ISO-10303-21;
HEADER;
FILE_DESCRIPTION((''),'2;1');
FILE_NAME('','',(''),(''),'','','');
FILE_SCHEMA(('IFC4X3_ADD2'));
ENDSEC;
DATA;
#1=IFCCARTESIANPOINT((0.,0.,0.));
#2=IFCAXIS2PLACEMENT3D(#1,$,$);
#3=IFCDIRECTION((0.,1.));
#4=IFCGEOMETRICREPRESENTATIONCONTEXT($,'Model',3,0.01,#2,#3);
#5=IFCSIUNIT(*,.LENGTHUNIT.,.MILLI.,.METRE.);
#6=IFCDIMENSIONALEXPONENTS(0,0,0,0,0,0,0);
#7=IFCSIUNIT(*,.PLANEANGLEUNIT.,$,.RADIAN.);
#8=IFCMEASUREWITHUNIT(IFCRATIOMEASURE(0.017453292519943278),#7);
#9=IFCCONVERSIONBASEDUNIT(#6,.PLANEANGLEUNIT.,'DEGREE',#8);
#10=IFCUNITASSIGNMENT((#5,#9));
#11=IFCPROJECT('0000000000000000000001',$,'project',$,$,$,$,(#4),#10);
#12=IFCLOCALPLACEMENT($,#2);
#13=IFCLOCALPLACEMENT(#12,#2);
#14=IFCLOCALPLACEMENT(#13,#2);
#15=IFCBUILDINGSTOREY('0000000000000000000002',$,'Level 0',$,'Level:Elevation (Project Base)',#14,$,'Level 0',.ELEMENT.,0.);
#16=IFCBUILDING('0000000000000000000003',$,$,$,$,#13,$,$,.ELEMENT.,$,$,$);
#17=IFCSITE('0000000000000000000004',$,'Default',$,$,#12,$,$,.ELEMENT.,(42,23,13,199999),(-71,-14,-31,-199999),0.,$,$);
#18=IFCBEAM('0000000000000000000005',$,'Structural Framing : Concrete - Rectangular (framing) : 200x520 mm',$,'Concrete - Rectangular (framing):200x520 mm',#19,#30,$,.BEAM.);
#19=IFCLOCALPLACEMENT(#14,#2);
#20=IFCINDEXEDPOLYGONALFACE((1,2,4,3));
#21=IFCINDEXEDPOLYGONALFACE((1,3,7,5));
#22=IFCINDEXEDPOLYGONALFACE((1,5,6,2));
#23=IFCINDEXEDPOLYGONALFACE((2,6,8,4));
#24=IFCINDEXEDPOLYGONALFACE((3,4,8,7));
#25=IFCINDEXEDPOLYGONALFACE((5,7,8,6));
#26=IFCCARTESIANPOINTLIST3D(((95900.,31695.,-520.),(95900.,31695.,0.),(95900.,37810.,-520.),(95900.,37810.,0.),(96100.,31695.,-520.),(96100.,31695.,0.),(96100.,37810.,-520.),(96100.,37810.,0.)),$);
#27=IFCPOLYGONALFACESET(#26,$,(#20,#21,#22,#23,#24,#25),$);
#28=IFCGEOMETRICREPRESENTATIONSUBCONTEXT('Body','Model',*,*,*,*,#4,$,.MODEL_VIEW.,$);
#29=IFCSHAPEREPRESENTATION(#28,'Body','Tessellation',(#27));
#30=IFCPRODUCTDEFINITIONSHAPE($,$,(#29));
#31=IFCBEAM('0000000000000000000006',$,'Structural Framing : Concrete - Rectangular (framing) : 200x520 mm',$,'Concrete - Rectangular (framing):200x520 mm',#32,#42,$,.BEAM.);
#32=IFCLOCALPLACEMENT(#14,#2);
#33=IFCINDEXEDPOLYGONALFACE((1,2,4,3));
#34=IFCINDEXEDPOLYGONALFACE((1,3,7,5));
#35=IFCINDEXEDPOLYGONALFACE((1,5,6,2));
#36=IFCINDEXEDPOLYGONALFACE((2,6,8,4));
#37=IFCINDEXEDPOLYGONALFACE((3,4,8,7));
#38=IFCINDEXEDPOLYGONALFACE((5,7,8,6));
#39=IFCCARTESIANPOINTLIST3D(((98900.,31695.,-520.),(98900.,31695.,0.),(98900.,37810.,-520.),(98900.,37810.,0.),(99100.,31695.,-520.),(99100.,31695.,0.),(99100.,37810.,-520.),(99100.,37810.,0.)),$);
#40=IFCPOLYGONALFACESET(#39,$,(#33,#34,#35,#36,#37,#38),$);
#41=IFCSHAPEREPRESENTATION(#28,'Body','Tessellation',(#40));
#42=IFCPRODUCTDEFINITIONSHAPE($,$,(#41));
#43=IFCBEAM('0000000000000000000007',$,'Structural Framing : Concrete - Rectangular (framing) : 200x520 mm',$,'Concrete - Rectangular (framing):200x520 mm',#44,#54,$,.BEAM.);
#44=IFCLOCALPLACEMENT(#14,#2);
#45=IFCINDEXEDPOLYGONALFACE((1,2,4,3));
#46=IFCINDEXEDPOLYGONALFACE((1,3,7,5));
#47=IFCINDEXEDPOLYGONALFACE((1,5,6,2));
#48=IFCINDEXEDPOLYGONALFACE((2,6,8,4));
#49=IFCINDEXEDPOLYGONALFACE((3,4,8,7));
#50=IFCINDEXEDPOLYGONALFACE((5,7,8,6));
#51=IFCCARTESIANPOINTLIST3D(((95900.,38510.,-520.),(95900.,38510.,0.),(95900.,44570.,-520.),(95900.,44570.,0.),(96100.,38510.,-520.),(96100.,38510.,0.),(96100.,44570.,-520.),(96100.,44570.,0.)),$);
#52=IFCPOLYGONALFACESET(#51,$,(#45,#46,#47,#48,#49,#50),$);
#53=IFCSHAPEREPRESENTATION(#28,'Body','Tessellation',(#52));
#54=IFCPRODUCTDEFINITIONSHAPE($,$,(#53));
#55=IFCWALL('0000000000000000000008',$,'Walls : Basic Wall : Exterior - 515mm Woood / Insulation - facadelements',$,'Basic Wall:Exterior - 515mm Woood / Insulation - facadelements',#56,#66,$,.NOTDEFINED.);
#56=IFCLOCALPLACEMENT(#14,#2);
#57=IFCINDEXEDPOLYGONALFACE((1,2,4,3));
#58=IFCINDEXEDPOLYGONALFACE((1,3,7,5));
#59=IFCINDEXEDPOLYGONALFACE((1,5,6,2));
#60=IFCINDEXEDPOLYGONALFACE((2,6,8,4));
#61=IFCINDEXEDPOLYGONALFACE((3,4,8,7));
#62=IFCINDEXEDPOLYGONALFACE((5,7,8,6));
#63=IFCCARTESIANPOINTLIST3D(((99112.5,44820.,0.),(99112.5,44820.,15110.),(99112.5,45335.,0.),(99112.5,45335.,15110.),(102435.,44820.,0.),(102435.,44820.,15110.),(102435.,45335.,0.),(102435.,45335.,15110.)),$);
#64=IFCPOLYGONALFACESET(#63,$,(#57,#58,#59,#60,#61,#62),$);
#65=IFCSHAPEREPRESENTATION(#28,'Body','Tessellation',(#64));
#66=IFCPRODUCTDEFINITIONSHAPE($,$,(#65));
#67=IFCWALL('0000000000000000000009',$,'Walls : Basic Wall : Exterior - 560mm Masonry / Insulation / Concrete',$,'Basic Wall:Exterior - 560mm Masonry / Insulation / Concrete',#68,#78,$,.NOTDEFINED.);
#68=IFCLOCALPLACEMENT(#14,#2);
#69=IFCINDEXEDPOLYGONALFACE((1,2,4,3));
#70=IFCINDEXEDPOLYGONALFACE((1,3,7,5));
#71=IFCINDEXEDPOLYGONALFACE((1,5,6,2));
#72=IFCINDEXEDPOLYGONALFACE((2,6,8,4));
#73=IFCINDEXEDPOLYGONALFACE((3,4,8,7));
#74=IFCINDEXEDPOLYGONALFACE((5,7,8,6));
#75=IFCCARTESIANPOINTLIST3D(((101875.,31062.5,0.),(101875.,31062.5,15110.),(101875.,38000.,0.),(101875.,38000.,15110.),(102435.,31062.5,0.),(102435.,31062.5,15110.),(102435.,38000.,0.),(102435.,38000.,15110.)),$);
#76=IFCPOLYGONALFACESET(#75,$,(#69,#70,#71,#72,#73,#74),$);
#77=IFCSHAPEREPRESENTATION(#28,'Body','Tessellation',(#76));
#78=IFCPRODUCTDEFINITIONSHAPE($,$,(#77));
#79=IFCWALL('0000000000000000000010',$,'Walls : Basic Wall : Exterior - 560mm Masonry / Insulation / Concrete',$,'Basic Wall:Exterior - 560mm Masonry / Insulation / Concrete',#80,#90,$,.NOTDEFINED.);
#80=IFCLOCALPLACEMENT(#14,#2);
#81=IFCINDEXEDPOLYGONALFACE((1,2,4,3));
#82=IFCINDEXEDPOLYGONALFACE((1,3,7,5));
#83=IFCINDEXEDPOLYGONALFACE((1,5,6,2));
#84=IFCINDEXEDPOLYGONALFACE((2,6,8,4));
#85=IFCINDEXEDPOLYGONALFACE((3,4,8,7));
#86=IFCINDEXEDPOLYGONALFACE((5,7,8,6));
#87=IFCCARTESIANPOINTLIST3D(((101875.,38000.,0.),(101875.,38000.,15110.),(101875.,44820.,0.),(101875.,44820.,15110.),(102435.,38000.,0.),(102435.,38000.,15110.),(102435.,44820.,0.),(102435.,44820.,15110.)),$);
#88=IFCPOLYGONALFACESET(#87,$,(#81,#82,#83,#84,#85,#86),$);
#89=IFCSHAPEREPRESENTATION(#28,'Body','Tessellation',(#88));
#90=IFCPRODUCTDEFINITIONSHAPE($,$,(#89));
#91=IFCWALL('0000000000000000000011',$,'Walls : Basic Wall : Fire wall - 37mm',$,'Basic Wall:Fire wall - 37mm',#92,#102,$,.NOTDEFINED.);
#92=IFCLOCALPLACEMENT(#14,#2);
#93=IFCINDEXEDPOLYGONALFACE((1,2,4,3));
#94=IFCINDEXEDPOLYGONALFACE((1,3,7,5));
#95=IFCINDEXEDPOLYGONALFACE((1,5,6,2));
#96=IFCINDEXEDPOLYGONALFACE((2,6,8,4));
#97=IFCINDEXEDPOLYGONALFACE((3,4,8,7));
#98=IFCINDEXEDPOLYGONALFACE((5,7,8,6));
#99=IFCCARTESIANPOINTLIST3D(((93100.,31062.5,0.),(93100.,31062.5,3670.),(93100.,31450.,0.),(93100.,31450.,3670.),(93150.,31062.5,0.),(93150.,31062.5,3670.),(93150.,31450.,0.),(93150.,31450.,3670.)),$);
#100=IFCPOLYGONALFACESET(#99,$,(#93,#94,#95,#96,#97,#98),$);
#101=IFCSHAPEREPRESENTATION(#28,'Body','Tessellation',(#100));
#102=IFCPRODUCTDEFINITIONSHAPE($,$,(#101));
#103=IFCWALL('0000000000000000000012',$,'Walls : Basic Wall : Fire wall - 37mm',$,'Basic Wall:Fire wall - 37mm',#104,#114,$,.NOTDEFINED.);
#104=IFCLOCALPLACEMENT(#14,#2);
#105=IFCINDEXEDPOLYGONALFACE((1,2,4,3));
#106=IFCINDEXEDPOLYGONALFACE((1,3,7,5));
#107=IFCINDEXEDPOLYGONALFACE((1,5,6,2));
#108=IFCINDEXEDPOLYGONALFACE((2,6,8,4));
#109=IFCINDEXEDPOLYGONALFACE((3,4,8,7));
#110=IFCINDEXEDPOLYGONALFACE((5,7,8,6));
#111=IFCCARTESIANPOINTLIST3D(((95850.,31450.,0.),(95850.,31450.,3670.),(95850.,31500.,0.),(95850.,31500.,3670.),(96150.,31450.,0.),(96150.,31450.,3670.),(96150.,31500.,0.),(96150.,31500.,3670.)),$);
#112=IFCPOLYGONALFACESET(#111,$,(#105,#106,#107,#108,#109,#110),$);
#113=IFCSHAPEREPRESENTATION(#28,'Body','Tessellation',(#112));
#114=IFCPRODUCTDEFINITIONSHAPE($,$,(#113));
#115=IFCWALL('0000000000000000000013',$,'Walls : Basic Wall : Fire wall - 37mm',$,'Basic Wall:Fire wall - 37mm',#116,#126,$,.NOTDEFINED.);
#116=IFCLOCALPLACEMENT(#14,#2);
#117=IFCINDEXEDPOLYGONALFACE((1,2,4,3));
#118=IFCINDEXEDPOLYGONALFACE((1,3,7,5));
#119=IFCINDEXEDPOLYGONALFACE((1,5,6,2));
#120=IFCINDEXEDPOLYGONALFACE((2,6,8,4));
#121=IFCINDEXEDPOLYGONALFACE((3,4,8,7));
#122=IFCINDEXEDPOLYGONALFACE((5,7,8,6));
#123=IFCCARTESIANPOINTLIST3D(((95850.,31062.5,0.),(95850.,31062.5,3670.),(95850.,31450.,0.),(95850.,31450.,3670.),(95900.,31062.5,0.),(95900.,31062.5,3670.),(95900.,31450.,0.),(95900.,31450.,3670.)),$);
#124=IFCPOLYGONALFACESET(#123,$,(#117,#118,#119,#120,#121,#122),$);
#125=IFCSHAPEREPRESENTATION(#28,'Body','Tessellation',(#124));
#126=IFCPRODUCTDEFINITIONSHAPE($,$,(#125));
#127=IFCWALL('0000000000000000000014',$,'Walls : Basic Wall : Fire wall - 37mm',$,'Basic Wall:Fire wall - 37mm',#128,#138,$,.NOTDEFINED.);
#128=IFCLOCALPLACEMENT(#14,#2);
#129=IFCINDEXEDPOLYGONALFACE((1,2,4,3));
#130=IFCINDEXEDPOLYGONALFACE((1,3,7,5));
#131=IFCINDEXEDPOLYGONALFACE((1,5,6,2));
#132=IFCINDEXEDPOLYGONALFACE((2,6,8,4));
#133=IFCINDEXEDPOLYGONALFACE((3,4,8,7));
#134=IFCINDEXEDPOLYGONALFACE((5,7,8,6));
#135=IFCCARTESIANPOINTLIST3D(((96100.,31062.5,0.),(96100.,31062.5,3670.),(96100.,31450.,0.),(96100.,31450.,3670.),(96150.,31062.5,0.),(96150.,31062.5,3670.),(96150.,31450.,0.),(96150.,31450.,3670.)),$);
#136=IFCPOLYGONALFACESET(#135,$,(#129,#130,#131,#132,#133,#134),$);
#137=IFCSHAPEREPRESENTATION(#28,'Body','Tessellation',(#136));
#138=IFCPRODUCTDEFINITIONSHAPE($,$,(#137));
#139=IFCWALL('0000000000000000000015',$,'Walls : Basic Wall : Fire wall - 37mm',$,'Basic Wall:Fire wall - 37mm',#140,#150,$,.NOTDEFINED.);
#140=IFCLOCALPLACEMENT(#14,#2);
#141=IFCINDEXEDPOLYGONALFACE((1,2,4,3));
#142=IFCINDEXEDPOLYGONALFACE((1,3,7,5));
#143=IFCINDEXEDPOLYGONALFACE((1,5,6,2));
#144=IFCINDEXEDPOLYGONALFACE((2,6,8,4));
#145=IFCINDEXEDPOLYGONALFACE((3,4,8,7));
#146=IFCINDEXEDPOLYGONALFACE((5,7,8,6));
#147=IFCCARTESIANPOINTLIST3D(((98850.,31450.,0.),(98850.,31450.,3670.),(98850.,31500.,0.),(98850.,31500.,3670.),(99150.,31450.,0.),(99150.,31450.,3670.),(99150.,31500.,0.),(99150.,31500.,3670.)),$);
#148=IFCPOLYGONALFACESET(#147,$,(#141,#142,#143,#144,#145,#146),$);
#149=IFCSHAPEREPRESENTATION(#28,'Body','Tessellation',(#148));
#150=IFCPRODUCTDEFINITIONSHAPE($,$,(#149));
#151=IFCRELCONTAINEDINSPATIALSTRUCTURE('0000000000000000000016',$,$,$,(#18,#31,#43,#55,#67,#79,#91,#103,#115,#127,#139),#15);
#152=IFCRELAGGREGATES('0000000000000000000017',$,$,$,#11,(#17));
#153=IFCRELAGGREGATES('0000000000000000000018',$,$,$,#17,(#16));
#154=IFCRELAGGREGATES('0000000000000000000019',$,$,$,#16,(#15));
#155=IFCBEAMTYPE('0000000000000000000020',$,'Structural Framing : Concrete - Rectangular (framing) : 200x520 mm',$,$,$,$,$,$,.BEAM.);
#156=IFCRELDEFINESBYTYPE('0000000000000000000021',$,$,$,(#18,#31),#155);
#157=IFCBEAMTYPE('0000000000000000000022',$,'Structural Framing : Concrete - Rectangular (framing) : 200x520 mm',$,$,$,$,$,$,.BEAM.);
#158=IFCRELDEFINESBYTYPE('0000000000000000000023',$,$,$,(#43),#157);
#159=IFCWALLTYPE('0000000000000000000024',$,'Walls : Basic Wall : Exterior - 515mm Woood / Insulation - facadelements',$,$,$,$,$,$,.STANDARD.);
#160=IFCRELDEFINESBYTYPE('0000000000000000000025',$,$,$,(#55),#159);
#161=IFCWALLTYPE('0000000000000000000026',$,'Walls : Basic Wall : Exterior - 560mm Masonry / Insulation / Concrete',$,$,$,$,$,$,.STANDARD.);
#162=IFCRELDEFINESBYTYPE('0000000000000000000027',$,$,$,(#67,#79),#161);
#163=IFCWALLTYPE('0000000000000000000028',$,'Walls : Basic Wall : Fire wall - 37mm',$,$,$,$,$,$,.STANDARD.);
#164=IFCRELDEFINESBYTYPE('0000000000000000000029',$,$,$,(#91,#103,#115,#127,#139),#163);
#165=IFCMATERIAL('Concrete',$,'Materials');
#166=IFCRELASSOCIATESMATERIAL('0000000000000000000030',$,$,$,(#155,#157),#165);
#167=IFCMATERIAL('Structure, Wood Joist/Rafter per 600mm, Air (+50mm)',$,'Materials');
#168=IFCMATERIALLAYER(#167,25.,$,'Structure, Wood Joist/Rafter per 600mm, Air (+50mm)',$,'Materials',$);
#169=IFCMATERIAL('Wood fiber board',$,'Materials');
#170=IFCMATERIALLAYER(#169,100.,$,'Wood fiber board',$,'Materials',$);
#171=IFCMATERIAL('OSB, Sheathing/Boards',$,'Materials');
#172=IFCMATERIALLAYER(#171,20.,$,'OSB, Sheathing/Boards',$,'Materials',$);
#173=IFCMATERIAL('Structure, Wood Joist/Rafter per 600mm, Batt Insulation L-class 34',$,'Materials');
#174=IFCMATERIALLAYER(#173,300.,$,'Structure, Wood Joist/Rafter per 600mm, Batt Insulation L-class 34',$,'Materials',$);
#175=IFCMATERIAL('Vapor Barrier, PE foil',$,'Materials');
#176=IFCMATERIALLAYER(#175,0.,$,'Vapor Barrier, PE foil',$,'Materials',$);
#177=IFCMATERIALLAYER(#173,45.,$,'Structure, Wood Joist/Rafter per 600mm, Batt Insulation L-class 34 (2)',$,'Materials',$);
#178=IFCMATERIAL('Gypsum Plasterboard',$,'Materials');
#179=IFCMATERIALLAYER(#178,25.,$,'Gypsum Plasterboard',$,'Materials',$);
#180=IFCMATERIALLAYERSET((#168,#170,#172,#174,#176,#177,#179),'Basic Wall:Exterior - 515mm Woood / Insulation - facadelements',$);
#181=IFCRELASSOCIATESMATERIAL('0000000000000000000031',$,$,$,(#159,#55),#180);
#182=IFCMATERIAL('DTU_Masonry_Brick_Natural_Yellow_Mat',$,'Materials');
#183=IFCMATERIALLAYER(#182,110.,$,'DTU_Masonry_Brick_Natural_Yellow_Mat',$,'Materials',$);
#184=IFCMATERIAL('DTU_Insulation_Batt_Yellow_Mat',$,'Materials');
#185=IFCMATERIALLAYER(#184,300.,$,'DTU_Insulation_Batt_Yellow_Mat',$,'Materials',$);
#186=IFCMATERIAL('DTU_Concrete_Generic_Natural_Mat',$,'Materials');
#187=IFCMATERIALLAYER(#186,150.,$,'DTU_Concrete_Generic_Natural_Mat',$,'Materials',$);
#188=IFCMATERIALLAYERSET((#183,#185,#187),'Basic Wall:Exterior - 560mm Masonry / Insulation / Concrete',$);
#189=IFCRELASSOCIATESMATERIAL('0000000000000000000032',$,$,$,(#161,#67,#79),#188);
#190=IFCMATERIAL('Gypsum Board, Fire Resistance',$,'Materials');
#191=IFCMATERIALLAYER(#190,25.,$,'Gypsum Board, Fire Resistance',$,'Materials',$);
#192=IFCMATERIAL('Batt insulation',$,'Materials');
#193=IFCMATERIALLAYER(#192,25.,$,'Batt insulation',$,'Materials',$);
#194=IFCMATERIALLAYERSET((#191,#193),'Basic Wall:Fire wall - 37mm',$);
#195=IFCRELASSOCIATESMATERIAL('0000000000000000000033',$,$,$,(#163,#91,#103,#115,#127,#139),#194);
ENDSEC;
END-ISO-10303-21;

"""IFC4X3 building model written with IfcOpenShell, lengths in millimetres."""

from ifc_helpers import new_model, entity, si_unit, converted_unit, direction, frame, frame_2d, origin, place, context, subcontext, project, spatial, rectangle, extrude, source, transform, mapped, material, layer, layer_set, material_profile, profile_set, type_object, type_shapes, element, save


model = new_model("IFC4X3")

# Units and contexts
model_context = context("Model", 3, precision=0.01, world=origin(), true_north=direction((0.0, 1.0)))
body_context = subcontext(model_context, "Body", "Model", "MODEL_VIEW")
ifc_project = project(units=[si_unit("LENGTHUNIT", "METRE", prefix="MILLI"), converted_unit("PLANEANGLEUNIT", "DEGREE", entity("IfcRatioMeasure", 0.017453292519943278), si_unit("PLANEANGLEUNIT", "RADIAN"), dimensions=[0, 0, 0, 0, 0, 0, 0])], contexts=[model_context])

# Site, building, storey
site_placement = place(None, origin())
site = spatial("IfcSite", under=ifc_project, at=site_placement, Name="Default", CompositionType="ELEMENT", RefLatitude=(42, 23, 13, 199999), RefLongitude=(-71, -14, -31, -199999), RefElevation=0.0)
building_placement = place(site_placement, origin())
building = spatial("IfcBuilding", under=site, at=building_placement, CompositionType="ELEMENT")
storey_placement = place(building_placement, origin())
storey = spatial("IfcBuildingStorey", under=building, at=storey_placement, Name="Level 0", ObjectType="Level:Elevation (Project Base)", LongName="Level 0", CompositionType="ELEMENT", Elevation=0.0)

# Beams
ifc_material_1 = material(Name="Concrete", Category="Materials")
ifc_material_profile = material_profile(ifc_material_1, rectangle(XDim=520.0, YDim=200.0, at=frame_2d((0.0, 0.0), x_axis=(1.0, 0.0))), Name="200x520 mm")
ifc_profile_set = profile_set([ifc_material_profile], Name="200x520 mm")
beam_type_1 = type_object("IfcBeamType", Name="Structural Framing : Concrete - Rectangular (framing) : 200x520 mm", PredefinedType="BEAM", material=ifc_profile_set)
shared_shape_1 = source(origin(), body_context, "Body", "SweptSolid", [
    extrude(rectangle(XDim=520.0, YDim=200.0, at=frame_2d((0.0, 0.0), x_axis=(1.0, 0.0))), frame((-970.0, 0.0, 0.0), z_axis=(1.0, 0.0, 0.0), x_axis=(0.0, 0.0, -1.0)), (0.0, 0.0, 1.0), 6115.0),
])
type_shapes(beam_type_1, [shared_shape_1])
for number, where, z_axis, x_axis, name in (
    (1, (96000.0, 36840.0, -260.0), (0.0, 0.0, 1.0), (0.0, -1.0, 0.0), "Structural Framing : Concrete - Rectangular (framing) : 200x520 mm"),
    (2, (99000.0, 36840.0, -260.0), (0.0, 0.0, 1.0), (0.0, -1.0, 0.0), "Structural Framing : Concrete - Rectangular (framing) : 200x520 mm"),
):
    element("IfcBeam", number, at=place(storey_placement, frame(where, z_axis=z_axis, x_axis=x_axis)), inside=storey, type_object=beam_type_1, Name=name, ObjectType="Concrete - Rectangular (framing):200x520 mm", PredefinedType="BEAM", context=body_context, shape_type="MappedRepresentation", body=[
        mapped(shared_shape_1, transform((0.0, 0.0, 0.0), scale=1.0)),
    ])
beam_type_2 = type_object("IfcBeamType", Name="Structural Framing : Concrete - Rectangular (framing) : 200x520 mm", PredefinedType="BEAM", material=ifc_profile_set)
shared_shape_2 = source(origin(), body_context, "Body", "SweptSolid", [
    extrude(rectangle(XDim=520.0, YDim=200.0, at=frame_2d((0.0, 0.0), x_axis=(1.0, 0.0))), frame((-1230.0, 0.0, 0.0), z_axis=(1.0, 0.0, 0.0), x_axis=(0.0, 0.0, -1.0)), (0.0, 0.0, 1.0), 6060.0),
])
type_shapes(beam_type_2, [shared_shape_2])
beam_placement = place(storey_placement, frame((96000.0, 43340.0, -260.0), z_axis=(0.0, 0.0, 1.0), x_axis=(0.0, -1.0, 0.0)))
element("IfcBeam", 3, at=beam_placement, inside=storey, type_object=beam_type_2, Name="Structural Framing : Concrete - Rectangular (framing) : 200x520 mm", ObjectType="Concrete - Rectangular (framing):200x520 mm", PredefinedType="BEAM", context=body_context, shape_type="MappedRepresentation", body=[
    mapped(shared_shape_2, transform((0.0, 0.0, 0.0), scale=1.0)),
])

# Walls
ifc_material_2 = material(Name="Structure, Wood Joist/Rafter per 600mm, Air (+50mm)", Category="Materials")
ifc_layer_1 = layer(ifc_material_2, 25.0, Name="Structure, Wood Joist/Rafter per 600mm, Air (+50mm)", Category="Materials")
ifc_material_3 = material(Name="Wood fiber board", Category="Materials")
ifc_layer_2 = layer(ifc_material_3, 100.0, Name="Wood fiber board", Category="Materials")
ifc_material_4 = material(Name="OSB, Sheathing/Boards", Category="Materials")
ifc_layer_3 = layer(ifc_material_4, 20.0, Name="OSB, Sheathing/Boards", Category="Materials")
ifc_material_5 = material(Name="Structure, Wood Joist/Rafter per 600mm, Batt Insulation L-class 34", Category="Materials")
ifc_layer_4 = layer(ifc_material_5, 300.0, Name="Structure, Wood Joist/Rafter per 600mm, Batt Insulation L-class 34", Category="Materials")
ifc_material_6 = material(Name="Vapor Barrier, PE foil", Category="Materials")
ifc_layer_5 = layer(ifc_material_6, 0.0, Name="Vapor Barrier, PE foil", Category="Materials")
ifc_layer_6 = layer(ifc_material_5, 45.0, Name="Structure, Wood Joist/Rafter per 600mm, Batt Insulation L-class 34 (2)", Category="Materials")
ifc_material_7 = material(Name="Gypsum Plasterboard", Category="Materials")
ifc_layer_7 = layer(ifc_material_7, 25.0, Name="Gypsum Plasterboard", Category="Materials")
ifc_layer_set_1 = layer_set([ifc_layer_1, ifc_layer_2, ifc_layer_3, ifc_layer_4, ifc_layer_5, ifc_layer_6, ifc_layer_7], Name="Basic Wall:Exterior - 515mm Woood / Insulation - facadelements")
wall_type_1 = type_object("IfcWallType", Name="Walls : Basic Wall : Exterior - 515mm Woood / Insulation - facadelements", PredefinedType="STANDARD", material=ifc_layer_set_1)
wall_1_placement = place(storey_placement, frame((99112.5, 45077.5, 0.0)))
element("IfcWall", 4, at=wall_1_placement, inside=storey, type_object=wall_type_1, material=ifc_layer_set_1, Name="Walls : Basic Wall : Exterior - 515mm Woood / Insulation - facadelements", ObjectType="Basic Wall:Exterior - 515mm Woood / Insulation - facadelements", PredefinedType="NOTDEFINED", context=body_context, shape_type="SweptSolid", body=[
    extrude(rectangle(XDim=3322.5, YDim=515.0, at=frame_2d((1661.2, 0.0), x_axis=(-1.0, 0.0))), origin(), (0.0, 0.0, 1.0), 15110.0),
])
ifc_material_8 = material(Name="DTU_Masonry_Brick_Natural_Yellow_Mat", Category="Materials")
ifc_layer_8 = layer(ifc_material_8, 110.0, Name="DTU_Masonry_Brick_Natural_Yellow_Mat", Category="Materials")
ifc_material_9 = material(Name="DTU_Insulation_Batt_Yellow_Mat", Category="Materials")
ifc_layer_9 = layer(ifc_material_9, 300.0, Name="DTU_Insulation_Batt_Yellow_Mat", Category="Materials")
ifc_material_10 = material(Name="DTU_Concrete_Generic_Natural_Mat", Category="Materials")
ifc_layer_10 = layer(ifc_material_10, 150.0, Name="DTU_Concrete_Generic_Natural_Mat", Category="Materials")
ifc_layer_set_2 = layer_set([ifc_layer_8, ifc_layer_9, ifc_layer_10], Name="Basic Wall:Exterior - 560mm Masonry / Insulation / Concrete")
wall_type_2 = type_object("IfcWallType", Name="Walls : Basic Wall : Exterior - 560mm Masonry / Insulation / Concrete", PredefinedType="STANDARD", material=ifc_layer_set_2)
wall_2_placement = place(storey_placement, frame((102155.0, 31062.5, 0.0), z_axis=(0.0, 0.0, 1.0), x_axis=(0.0, 1.0, 0.0)))
element("IfcWall", 5, at=wall_2_placement, inside=storey, type_object=wall_type_2, material=ifc_layer_set_2, Name="Walls : Basic Wall : Exterior - 560mm Masonry / Insulation / Concrete", ObjectType="Basic Wall:Exterior - 560mm Masonry / Insulation / Concrete", PredefinedType="NOTDEFINED", context=body_context, shape_type="SweptSolid", body=[
    extrude(rectangle(XDim=6937.5, YDim=560.0, at=frame_2d((3468.7, 0.0), x_axis=(-1.0, 0.0))), origin(), (0.0, 0.0, 1.0), 15110.0),
])
wall_3_placement = place(storey_placement, frame((102155.0, 38000.0, 0.0), z_axis=(0.0, 0.0, 1.0), x_axis=(0.0, 1.0, 0.0)))
element("IfcWall", 6, at=wall_3_placement, inside=storey, type_object=wall_type_2, material=ifc_layer_set_2, Name="Walls : Basic Wall : Exterior - 560mm Masonry / Insulation / Concrete", ObjectType="Basic Wall:Exterior - 560mm Masonry / Insulation / Concrete", PredefinedType="NOTDEFINED", context=body_context, shape_type="SweptSolid", body=[
    extrude(rectangle(XDim=6820.0, YDim=560.0, at=frame_2d((3410.0, 0.0), x_axis=(-1.0, 0.0))), origin(), (0.0, 0.0, 1.0), 15110.0),
])
ifc_material_11 = material(Name="Gypsum Board, Fire Resistance", Category="Materials")
ifc_layer_11 = layer(ifc_material_11, 25.0, Name="Gypsum Board, Fire Resistance", Category="Materials")
ifc_material_12 = material(Name="Batt insulation", Category="Materials")
ifc_layer_12 = layer(ifc_material_12, 25.0, Name="Batt insulation", Category="Materials")
ifc_layer_set_3 = layer_set([ifc_layer_11, ifc_layer_12], Name="Basic Wall:Fire wall - 37mm")
wall_type_3 = type_object("IfcWallType", Name="Walls : Basic Wall : Fire wall - 37mm", PredefinedType="STANDARD", material=ifc_layer_set_3)
wall_4_placement = place(storey_placement, frame((93125.0, 31450.0, 0.0), z_axis=(0.0, 0.0, 1.0), x_axis=(0.0, -1.0, 0.0)))
element("IfcWall", 7, at=wall_4_placement, inside=storey, type_object=wall_type_3, material=ifc_layer_set_3, Name="Walls : Basic Wall : Fire wall - 37mm", ObjectType="Basic Wall:Fire wall - 37mm", PredefinedType="NOTDEFINED", context=body_context, shape_type="SweptSolid", body=[
    extrude(rectangle(XDim=387.5, YDim=50.0, at=frame_2d((193.8, 0.0), x_axis=(-1.0, 0.0))), origin(), (0.0, 0.0, 1.0), 3670.0),
])
wall_5_placement = place(storey_placement, frame((95850.0, 31475.0, 0.0)))
element("IfcWall", 8, at=wall_5_placement, inside=storey, type_object=wall_type_3, material=ifc_layer_set_3, Name="Walls : Basic Wall : Fire wall - 37mm", ObjectType="Basic Wall:Fire wall - 37mm", PredefinedType="NOTDEFINED", context=body_context, shape_type="SweptSolid", body=[
    extrude(rectangle(XDim=300.0, YDim=50.0, at=frame_2d((150.0, 0.0), x_axis=(-1.0, 0.0))), origin(), (0.0, 0.0, 1.0), 3670.0),
])
wall_6_placement = place(storey_placement, frame((95875.0, 31450.0, 0.0), z_axis=(0.0, 0.0, 1.0), x_axis=(0.0, -1.0, 0.0)))
element("IfcWall", 9, at=wall_6_placement, inside=storey, type_object=wall_type_3, material=ifc_layer_set_3, Name="Walls : Basic Wall : Fire wall - 37mm", ObjectType="Basic Wall:Fire wall - 37mm", PredefinedType="NOTDEFINED", context=body_context, shape_type="SweptSolid", body=[
    extrude(rectangle(XDim=387.5, YDim=50.0, at=frame_2d((193.8, 0.0), x_axis=(-1.0, 0.0))), origin(), (0.0, 0.0, 1.0), 3670.0),
])
wall_7_placement = place(storey_placement, frame((96125.0, 31450.0, 0.0), z_axis=(0.0, 0.0, 1.0), x_axis=(0.0, -1.0, 0.0)))
element("IfcWall", 10, at=wall_7_placement, inside=storey, type_object=wall_type_3, material=ifc_layer_set_3, Name="Walls : Basic Wall : Fire wall - 37mm", ObjectType="Basic Wall:Fire wall - 37mm", PredefinedType="NOTDEFINED", context=body_context, shape_type="SweptSolid", body=[
    extrude(rectangle(XDim=387.5, YDim=50.0, at=frame_2d((193.8, 0.0), x_axis=(-1.0, 0.0))), origin(), (0.0, 0.0, 1.0), 3670.0),
])
wall_8_placement = place(storey_placement, frame((98850.0, 31475.0, 0.0)))
element("IfcWall", 11, at=wall_8_placement, inside=storey, type_object=wall_type_3, material=ifc_layer_set_3, Name="Walls : Basic Wall : Fire wall - 37mm", ObjectType="Basic Wall:Fire wall - 37mm", PredefinedType="NOTDEFINED", context=body_context, shape_type="SweptSolid", body=[
    extrude(rectangle(XDim=300.0, YDim=50.0, at=frame_2d((150.0, 0.0), x_axis=(-1.0, 0.0))), origin(), (0.0, 0.0, 1.0), 3670.0),
])

save(model, "model.ifc")
